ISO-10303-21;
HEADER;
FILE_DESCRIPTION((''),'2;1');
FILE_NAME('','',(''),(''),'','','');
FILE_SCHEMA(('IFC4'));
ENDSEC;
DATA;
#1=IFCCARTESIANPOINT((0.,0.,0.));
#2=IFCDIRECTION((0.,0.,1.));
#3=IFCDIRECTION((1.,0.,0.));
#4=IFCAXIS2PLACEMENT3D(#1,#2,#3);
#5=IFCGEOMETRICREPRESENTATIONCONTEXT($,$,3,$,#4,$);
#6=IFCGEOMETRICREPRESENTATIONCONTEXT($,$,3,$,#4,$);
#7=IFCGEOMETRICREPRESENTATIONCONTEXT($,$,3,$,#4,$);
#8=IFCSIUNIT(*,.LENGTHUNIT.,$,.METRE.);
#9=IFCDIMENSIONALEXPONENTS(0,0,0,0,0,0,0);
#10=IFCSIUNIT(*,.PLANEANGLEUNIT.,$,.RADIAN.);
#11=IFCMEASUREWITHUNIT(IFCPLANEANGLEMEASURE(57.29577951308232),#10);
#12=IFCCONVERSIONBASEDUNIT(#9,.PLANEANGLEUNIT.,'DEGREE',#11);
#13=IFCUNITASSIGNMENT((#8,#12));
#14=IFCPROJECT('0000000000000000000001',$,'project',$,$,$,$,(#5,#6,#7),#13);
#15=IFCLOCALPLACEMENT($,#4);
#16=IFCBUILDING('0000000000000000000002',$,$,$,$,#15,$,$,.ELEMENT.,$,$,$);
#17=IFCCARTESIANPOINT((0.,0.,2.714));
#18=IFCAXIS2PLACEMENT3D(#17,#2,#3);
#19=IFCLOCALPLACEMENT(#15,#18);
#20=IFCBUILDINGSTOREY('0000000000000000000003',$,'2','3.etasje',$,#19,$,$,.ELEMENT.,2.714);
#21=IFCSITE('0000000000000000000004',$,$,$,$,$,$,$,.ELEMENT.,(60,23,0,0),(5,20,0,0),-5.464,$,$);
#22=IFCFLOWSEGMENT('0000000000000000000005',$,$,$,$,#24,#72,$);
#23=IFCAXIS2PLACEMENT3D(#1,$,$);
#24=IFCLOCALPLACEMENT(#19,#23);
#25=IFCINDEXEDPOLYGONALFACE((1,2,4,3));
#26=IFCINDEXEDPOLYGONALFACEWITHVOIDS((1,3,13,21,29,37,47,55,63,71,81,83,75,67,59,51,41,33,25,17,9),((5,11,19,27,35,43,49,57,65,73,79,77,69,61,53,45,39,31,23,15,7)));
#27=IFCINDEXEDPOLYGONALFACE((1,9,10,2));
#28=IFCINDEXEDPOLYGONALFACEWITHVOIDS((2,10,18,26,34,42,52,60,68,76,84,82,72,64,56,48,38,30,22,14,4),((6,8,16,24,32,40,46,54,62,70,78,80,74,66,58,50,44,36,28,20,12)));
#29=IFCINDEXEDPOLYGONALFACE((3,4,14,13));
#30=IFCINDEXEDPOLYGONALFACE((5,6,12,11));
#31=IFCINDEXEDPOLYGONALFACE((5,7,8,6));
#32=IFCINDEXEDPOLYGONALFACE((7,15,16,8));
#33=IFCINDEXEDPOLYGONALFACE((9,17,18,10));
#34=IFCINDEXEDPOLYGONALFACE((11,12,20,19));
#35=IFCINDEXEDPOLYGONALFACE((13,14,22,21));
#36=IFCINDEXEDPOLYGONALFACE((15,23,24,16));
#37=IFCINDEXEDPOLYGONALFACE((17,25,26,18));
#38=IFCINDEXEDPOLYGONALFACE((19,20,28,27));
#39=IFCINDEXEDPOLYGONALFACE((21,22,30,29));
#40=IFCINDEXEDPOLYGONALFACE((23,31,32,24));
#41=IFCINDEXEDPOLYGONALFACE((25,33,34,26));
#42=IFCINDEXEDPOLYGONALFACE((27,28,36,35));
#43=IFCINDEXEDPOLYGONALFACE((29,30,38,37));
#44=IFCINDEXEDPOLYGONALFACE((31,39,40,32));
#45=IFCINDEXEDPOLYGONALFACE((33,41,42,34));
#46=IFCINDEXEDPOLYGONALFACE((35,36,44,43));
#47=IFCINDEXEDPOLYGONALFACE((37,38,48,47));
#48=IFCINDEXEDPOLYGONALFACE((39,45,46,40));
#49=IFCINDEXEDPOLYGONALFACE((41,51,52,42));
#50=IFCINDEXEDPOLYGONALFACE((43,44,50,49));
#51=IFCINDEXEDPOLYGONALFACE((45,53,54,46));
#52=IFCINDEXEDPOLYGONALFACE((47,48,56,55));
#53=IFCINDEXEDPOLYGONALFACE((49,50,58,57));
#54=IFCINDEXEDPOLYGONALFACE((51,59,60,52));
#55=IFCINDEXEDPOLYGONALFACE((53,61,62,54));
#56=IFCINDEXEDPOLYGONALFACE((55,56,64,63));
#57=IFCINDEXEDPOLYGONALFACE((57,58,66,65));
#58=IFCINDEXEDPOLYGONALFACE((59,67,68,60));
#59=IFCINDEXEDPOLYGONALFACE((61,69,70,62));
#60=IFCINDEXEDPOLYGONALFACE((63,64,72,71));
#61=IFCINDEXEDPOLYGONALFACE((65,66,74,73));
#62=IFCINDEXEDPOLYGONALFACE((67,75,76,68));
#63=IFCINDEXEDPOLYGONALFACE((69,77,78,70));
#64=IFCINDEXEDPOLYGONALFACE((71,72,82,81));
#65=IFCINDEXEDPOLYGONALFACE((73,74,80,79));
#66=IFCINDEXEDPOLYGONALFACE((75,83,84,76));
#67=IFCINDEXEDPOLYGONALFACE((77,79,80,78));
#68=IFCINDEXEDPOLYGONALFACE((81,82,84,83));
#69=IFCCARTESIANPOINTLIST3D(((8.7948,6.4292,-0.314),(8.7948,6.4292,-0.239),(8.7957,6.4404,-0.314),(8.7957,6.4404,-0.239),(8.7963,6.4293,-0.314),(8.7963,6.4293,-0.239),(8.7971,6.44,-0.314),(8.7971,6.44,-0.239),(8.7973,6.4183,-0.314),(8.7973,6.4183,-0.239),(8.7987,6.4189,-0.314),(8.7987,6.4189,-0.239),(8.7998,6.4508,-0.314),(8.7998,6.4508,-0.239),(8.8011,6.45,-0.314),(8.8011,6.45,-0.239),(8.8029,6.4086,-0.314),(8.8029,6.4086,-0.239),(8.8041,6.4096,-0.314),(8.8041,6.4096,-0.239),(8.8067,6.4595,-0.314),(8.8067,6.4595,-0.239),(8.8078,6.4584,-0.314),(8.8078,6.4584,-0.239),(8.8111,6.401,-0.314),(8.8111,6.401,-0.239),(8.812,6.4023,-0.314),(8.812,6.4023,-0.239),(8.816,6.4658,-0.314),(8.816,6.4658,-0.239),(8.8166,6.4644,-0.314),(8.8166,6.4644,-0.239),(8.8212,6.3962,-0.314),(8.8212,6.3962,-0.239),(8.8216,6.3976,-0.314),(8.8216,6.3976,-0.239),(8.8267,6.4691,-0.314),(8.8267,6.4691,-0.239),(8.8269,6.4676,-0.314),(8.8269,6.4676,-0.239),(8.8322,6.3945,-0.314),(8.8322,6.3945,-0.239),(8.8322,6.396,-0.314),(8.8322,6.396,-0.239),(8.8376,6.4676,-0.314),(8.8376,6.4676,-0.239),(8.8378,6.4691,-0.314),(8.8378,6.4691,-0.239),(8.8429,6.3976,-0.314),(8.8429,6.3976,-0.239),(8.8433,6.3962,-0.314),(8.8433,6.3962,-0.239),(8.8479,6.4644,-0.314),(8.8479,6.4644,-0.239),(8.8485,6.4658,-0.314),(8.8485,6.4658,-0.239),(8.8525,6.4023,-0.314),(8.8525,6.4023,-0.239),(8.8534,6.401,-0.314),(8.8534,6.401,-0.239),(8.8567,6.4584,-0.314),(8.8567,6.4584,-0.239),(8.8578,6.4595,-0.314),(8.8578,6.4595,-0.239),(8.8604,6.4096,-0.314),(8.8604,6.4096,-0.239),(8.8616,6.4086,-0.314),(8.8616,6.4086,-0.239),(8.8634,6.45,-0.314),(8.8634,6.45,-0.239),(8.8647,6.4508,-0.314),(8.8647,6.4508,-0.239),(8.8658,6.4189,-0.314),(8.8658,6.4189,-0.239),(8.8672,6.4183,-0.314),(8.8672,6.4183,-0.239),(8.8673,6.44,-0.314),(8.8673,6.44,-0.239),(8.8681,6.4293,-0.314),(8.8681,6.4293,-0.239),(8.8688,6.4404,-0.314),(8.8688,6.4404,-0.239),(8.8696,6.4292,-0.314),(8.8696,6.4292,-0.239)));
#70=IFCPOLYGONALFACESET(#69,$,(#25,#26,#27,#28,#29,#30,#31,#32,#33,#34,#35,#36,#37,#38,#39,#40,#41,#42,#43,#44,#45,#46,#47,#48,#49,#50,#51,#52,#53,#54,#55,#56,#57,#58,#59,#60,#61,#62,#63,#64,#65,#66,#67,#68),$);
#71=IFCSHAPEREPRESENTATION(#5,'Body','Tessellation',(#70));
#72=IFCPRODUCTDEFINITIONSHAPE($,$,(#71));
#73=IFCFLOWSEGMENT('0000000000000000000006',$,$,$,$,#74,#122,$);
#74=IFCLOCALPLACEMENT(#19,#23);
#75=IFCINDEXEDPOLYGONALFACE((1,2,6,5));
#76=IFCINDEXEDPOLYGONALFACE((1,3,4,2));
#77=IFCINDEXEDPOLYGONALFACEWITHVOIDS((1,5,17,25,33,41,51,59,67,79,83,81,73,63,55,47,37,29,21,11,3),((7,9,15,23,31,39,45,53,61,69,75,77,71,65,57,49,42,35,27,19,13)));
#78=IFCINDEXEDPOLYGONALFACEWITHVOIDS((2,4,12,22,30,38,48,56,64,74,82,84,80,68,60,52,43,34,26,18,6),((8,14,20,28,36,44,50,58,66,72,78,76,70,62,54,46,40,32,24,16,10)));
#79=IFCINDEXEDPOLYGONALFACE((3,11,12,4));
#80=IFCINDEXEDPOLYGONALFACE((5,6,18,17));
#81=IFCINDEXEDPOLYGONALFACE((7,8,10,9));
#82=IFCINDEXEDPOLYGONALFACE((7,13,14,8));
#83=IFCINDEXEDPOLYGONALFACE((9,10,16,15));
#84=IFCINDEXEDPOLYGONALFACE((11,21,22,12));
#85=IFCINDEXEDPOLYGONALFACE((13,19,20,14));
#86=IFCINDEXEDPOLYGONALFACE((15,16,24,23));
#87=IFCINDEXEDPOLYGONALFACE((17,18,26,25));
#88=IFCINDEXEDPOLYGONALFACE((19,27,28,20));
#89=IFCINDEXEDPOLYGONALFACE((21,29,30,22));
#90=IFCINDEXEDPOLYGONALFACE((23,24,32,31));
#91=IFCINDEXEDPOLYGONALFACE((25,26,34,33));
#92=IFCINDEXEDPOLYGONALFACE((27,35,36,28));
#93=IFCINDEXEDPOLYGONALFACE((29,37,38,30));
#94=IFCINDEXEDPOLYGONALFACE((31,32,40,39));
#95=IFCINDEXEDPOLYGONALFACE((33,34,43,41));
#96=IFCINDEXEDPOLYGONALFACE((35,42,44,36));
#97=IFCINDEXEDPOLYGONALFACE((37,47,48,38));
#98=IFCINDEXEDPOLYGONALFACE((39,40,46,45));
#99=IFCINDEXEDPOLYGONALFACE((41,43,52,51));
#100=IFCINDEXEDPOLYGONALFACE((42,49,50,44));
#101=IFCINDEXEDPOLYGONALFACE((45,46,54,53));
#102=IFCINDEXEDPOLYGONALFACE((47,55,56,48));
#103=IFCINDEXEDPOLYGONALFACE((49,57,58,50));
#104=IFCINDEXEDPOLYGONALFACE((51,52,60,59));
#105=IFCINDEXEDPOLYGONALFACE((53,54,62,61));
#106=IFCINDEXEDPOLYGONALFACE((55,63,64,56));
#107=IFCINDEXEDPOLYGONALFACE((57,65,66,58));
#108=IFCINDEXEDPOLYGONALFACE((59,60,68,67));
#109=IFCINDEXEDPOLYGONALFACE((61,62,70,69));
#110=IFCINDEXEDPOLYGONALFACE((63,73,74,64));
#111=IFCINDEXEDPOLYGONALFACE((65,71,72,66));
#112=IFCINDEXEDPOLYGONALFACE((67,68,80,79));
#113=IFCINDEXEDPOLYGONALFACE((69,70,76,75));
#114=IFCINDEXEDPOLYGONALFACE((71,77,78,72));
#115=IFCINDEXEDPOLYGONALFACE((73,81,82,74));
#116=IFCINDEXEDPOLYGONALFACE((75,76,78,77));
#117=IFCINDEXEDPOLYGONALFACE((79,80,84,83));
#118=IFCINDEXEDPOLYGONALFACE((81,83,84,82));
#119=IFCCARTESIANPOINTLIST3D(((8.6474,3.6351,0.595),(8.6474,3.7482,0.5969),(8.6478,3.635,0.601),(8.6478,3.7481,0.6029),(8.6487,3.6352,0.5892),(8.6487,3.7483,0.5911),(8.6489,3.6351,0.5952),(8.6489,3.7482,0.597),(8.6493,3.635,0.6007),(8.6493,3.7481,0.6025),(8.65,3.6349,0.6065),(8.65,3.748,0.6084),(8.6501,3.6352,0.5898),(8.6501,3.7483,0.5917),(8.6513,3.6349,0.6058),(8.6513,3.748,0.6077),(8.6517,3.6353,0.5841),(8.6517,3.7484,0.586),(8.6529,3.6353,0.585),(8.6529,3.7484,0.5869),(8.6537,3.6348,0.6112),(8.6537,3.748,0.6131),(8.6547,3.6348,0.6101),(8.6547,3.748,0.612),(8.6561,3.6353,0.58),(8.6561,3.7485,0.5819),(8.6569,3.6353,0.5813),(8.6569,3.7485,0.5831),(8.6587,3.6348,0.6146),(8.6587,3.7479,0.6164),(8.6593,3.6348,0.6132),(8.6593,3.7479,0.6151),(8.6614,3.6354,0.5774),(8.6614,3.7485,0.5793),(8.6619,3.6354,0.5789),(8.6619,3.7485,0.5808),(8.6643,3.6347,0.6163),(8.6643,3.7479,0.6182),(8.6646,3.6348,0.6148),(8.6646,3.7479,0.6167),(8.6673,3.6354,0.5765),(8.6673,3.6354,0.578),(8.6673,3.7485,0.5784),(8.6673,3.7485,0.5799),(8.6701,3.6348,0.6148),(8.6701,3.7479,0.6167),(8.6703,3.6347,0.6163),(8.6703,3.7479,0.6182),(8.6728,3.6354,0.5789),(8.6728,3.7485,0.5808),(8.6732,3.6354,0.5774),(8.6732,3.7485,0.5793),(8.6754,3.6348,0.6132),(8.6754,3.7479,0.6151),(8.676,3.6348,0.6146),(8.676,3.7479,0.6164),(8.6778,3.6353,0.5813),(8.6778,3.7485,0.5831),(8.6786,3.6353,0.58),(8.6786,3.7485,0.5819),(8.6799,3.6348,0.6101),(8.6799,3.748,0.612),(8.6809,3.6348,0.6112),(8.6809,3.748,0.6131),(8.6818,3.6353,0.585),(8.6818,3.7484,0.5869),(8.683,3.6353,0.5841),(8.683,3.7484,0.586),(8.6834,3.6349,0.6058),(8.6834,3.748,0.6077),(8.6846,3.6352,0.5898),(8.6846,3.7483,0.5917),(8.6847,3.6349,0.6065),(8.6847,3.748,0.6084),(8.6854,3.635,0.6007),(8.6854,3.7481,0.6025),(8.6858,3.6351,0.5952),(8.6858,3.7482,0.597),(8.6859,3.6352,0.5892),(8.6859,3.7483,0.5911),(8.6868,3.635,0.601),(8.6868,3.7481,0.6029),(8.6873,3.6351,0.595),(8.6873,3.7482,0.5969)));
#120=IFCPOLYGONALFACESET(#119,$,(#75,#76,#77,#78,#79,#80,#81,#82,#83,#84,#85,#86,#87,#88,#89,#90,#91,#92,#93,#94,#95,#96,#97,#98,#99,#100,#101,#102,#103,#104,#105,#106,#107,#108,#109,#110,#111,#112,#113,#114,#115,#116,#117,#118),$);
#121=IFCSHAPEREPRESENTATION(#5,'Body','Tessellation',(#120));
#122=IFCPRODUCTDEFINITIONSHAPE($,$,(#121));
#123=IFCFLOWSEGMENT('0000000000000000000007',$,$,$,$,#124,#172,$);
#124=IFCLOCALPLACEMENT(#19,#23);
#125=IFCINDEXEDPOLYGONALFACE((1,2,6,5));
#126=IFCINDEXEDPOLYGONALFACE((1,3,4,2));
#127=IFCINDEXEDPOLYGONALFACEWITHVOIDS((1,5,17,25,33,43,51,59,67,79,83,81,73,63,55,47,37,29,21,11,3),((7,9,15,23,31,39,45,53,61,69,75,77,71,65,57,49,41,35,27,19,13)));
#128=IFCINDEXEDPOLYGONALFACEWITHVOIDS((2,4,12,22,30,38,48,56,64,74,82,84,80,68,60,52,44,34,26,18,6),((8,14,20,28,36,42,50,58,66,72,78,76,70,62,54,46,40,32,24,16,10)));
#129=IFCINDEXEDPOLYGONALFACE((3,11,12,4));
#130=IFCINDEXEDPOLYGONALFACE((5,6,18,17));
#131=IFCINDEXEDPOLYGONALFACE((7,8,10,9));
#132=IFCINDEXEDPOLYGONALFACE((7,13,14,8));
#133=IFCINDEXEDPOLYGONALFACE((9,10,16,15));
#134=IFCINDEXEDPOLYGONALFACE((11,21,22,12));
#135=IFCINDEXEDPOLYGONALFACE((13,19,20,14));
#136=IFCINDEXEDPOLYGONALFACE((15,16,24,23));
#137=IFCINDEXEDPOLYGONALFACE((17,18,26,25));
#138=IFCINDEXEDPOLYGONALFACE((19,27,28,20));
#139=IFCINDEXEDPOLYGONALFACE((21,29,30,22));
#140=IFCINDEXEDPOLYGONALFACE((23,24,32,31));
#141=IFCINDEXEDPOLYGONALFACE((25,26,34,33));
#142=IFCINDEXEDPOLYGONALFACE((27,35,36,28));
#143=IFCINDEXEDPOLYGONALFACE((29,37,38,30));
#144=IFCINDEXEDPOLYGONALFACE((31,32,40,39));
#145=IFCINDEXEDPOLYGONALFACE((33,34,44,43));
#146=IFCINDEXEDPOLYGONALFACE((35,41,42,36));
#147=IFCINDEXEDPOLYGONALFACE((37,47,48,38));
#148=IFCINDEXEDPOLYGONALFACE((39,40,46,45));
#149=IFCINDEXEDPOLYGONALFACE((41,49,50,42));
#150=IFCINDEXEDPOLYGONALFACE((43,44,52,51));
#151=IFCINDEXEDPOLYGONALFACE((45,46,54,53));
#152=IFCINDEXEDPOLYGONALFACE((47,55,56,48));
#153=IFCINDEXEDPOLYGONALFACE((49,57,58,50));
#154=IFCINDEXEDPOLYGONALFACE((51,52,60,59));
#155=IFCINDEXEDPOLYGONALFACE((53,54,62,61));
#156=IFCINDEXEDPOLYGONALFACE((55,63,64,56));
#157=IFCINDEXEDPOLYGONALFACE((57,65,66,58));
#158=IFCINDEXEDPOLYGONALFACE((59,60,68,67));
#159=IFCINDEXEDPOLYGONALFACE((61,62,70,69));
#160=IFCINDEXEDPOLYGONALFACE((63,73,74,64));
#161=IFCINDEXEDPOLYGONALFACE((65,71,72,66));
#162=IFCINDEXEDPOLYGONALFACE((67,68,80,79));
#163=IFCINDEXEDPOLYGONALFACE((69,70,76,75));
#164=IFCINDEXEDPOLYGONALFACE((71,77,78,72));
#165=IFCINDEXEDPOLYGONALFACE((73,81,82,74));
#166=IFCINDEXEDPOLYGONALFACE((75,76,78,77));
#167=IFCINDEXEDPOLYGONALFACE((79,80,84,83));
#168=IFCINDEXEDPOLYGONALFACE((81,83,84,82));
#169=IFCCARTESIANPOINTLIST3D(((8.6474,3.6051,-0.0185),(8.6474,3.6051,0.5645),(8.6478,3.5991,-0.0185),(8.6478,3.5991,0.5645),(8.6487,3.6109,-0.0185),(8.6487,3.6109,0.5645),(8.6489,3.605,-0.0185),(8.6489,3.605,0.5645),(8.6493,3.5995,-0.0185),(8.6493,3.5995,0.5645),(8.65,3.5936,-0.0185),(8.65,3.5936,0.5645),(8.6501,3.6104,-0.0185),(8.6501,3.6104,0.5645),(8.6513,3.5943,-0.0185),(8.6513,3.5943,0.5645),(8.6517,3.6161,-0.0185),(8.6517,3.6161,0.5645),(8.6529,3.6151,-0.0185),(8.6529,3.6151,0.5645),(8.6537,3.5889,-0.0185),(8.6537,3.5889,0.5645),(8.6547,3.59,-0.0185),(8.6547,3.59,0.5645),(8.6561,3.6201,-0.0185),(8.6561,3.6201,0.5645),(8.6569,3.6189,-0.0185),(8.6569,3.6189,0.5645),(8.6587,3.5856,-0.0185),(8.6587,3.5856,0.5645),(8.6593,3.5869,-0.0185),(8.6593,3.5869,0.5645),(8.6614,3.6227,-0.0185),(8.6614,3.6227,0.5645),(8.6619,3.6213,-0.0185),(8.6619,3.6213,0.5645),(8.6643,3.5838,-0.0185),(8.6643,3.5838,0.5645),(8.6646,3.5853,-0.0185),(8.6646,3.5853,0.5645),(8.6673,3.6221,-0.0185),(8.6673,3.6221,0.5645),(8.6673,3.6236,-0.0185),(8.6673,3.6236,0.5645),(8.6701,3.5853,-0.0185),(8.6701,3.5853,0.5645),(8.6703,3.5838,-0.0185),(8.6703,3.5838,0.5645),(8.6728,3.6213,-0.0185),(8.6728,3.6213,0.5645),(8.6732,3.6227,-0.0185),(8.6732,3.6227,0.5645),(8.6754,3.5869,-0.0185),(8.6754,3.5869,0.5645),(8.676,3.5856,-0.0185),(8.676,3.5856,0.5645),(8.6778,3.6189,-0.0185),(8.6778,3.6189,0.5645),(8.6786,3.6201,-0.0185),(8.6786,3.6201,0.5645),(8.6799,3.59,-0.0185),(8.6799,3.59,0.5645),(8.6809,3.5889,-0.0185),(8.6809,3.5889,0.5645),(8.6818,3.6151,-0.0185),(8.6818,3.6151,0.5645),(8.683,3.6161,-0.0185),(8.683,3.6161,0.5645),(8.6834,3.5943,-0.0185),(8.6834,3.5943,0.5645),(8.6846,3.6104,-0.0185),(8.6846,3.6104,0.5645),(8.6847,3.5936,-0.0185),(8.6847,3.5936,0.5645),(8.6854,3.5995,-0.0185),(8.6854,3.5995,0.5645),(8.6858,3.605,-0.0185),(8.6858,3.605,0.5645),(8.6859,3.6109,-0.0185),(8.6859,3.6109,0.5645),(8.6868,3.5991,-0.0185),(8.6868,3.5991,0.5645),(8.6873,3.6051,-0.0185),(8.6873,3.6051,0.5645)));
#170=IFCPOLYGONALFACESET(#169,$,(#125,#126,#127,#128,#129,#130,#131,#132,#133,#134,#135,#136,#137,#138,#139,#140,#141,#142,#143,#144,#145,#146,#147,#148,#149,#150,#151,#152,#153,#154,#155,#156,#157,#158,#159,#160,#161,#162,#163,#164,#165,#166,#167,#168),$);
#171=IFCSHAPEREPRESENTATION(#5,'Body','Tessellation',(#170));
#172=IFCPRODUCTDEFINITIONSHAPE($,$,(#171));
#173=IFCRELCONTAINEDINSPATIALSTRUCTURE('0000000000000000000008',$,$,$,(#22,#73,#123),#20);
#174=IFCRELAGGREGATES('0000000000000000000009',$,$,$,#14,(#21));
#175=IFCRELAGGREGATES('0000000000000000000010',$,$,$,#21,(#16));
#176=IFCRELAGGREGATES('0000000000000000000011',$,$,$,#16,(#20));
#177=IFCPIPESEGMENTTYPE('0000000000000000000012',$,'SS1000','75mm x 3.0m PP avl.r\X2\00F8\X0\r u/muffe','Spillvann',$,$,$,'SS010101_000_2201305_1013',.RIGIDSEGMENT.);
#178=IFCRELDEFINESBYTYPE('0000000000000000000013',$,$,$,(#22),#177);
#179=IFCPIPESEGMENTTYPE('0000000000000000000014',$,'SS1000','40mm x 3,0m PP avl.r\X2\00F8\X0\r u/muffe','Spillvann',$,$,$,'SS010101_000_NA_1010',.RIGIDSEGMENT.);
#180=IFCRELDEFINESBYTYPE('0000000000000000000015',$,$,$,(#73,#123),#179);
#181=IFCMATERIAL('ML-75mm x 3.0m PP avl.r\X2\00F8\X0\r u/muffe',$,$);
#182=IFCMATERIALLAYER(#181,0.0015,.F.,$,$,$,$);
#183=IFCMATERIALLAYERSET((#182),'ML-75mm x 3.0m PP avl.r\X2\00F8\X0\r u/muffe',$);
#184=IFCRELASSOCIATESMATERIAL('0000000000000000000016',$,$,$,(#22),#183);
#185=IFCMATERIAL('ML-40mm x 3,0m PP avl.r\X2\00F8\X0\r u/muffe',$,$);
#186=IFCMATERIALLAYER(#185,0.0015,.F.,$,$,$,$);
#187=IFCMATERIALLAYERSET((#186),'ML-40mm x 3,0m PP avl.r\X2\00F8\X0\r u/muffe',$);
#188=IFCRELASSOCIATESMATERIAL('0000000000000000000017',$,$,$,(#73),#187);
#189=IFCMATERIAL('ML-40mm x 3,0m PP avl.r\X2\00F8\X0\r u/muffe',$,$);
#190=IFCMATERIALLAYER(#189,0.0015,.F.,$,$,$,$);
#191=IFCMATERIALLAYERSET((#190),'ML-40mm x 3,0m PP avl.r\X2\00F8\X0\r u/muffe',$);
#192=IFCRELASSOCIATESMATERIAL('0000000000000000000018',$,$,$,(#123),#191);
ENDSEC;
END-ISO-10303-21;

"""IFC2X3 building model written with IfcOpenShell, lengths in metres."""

from ifc_helpers import new_model, entity, si_unit, converted_unit, frame, origin_with_axes, origin_2d_with_axis, place, context, project, spatial, hollow_circle, extrude, material, layer, layer_set, layer_usage, type_object, element, save


model = new_model("IFC2X3")

# Units and contexts
context_of_model_1 = context(None, 3, world=origin_with_axes())
context_of_model_2 = context(None, 3, world=origin_with_axes())
context_of_model_3 = context(None, 3, world=origin_with_axes())
ifc_project = project(units=[si_unit("LENGTHUNIT", "METRE"), converted_unit("PLANEANGLEUNIT", "DEGREE", entity("IfcPlaneAngleMeasure", 57.29577951308232), si_unit("PLANEANGLEUNIT", "RADIAN"), dimensions=[0, 0, 0, 0, 0, 0, 0])], contexts=[context_of_model_1, context_of_model_2, context_of_model_3])

# Site, building, storey
site = spatial("IfcSite", under=ifc_project, CompositionType="ELEMENT", RefLatitude=(60, 23, 0, 0), RefLongitude=(5, 20, 0, 0), RefElevation=-5.464)
building_placement = place(None, origin_with_axes())
building = spatial("IfcBuilding", under=site, at=building_placement, CompositionType="ELEMENT")
storey_placement = place(building_placement, frame((0.0, 0.0, 2.714), z_axis=(0.0, 0.0, 1.0), x_axis=(1.0, 0.0, 0.0)))
storey = spatial("IfcBuildingStorey", under=building, at=storey_placement, Name="2", Description="3.etasje", CompositionType="ELEMENT", Elevation=2.714)

# Flow segments
pipe_segment_type_1 = type_object("IfcPipeSegmentType", Name="SS1000", Description="75mm x 3.0m PP avl.rør u/muffe", ApplicableOccurrence="Spillvann", ElementType="SS010101_000_2201305_1013", PredefinedType="RIGIDSEGMENT")
ifc_material_1 = material(Name="ML-75mm x 3.0m PP avl.rør u/muffe")
ifc_layer_1 = layer(ifc_material_1, 0.0015, ventilated=False)
ifc_layer_set_1 = layer_set([ifc_layer_1], Name="ML-75mm x 3.0m PP avl.rør u/muffe")
ifc_layer_usage_1 = layer_usage(ifc_layer_set_1, "AXIS2", "POSITIVE", 0.0)
flow_segment_1_placement = place(storey_placement, frame((8.8322, 6.432, -0.239), z_axis=(0.0, 0.0, -1.0), x_axis=(0.0, -1.0, 0.0)))
element("IfcFlowSegment", 1, at=flow_segment_1_placement, inside=storey, type_object=pipe_segment_type_1, material=ifc_layer_usage_1, context=context_of_model_1, shape_type="SweptSolid", body=[
    extrude(hollow_circle(Radius=0.0375, WallThickness=0.0015, at=origin_2d_with_axis()), origin_with_axes(), (0.0, 0.0, 1.0), 0.075),
])
ifc_material_2 = material(Name="ML-40mm x 3,0m PP avl.rør u/muffe")
ifc_layer_2 = layer(ifc_material_2, 0.0015, ventilated=False)
ifc_layer_set_2 = layer_set([ifc_layer_2], Name="ML-40mm x 3,0m PP avl.rør u/muffe")
ifc_layer_usage_2 = layer_usage(ifc_layer_set_2, "AXIS2", "POSITIVE", 0.0)
pipe_segment_type_2 = type_object("IfcPipeSegmentType", Name="SS1000", Description="40mm x 3,0m PP avl.rør u/muffe", ApplicableOccurrence="Spillvann", ElementType="SS010101_000_NA_1010", PredefinedType="RIGIDSEGMENT")
flow_segment_2_placement = place(storey_placement, frame((8.6673, 3.7482, 0.5984), z_axis=(0.0, -0.999861, -0.016664), x_axis=(0.0, 0.016664, -0.999861)))
element("IfcFlowSegment", 2, at=flow_segment_2_placement, inside=storey, type_object=pipe_segment_type_2, material=ifc_layer_usage_2, context=context_of_model_1, shape_type="SweptSolid", body=[
    extrude(hollow_circle(Radius=0.02, WallThickness=0.0015, at=origin_2d_with_axis()), origin_with_axes(), (0.0, 0.0, 1.0), 0.1132),
])
ifc_material_3 = material(Name="ML-40mm x 3,0m PP avl.rør u/muffe")
ifc_layer_3 = layer(ifc_material_3, 0.0015, ventilated=False)
ifc_layer_set_3 = layer_set([ifc_layer_3], Name="ML-40mm x 3,0m PP avl.rør u/muffe")
ifc_layer_usage_3 = layer_usage(ifc_layer_set_3, "AXIS2", "POSITIVE", 0.0)
flow_segment_3_placement = place(storey_placement, frame((8.6673, 3.6036, 0.5645), z_axis=(0.0, 0.0, -1.0), x_axis=(0.0, 1.0, 0.0)))
element("IfcFlowSegment", 3, at=flow_segment_3_placement, inside=storey, type_object=pipe_segment_type_2, material=ifc_layer_usage_3, context=context_of_model_1, shape_type="SweptSolid", body=[
    extrude(hollow_circle(Radius=0.02, WallThickness=0.0015, at=origin_2d_with_axis()), origin_with_axes(), (0.0, 0.0, 1.0), 0.5831),
])

save(model, "model.ifc")
